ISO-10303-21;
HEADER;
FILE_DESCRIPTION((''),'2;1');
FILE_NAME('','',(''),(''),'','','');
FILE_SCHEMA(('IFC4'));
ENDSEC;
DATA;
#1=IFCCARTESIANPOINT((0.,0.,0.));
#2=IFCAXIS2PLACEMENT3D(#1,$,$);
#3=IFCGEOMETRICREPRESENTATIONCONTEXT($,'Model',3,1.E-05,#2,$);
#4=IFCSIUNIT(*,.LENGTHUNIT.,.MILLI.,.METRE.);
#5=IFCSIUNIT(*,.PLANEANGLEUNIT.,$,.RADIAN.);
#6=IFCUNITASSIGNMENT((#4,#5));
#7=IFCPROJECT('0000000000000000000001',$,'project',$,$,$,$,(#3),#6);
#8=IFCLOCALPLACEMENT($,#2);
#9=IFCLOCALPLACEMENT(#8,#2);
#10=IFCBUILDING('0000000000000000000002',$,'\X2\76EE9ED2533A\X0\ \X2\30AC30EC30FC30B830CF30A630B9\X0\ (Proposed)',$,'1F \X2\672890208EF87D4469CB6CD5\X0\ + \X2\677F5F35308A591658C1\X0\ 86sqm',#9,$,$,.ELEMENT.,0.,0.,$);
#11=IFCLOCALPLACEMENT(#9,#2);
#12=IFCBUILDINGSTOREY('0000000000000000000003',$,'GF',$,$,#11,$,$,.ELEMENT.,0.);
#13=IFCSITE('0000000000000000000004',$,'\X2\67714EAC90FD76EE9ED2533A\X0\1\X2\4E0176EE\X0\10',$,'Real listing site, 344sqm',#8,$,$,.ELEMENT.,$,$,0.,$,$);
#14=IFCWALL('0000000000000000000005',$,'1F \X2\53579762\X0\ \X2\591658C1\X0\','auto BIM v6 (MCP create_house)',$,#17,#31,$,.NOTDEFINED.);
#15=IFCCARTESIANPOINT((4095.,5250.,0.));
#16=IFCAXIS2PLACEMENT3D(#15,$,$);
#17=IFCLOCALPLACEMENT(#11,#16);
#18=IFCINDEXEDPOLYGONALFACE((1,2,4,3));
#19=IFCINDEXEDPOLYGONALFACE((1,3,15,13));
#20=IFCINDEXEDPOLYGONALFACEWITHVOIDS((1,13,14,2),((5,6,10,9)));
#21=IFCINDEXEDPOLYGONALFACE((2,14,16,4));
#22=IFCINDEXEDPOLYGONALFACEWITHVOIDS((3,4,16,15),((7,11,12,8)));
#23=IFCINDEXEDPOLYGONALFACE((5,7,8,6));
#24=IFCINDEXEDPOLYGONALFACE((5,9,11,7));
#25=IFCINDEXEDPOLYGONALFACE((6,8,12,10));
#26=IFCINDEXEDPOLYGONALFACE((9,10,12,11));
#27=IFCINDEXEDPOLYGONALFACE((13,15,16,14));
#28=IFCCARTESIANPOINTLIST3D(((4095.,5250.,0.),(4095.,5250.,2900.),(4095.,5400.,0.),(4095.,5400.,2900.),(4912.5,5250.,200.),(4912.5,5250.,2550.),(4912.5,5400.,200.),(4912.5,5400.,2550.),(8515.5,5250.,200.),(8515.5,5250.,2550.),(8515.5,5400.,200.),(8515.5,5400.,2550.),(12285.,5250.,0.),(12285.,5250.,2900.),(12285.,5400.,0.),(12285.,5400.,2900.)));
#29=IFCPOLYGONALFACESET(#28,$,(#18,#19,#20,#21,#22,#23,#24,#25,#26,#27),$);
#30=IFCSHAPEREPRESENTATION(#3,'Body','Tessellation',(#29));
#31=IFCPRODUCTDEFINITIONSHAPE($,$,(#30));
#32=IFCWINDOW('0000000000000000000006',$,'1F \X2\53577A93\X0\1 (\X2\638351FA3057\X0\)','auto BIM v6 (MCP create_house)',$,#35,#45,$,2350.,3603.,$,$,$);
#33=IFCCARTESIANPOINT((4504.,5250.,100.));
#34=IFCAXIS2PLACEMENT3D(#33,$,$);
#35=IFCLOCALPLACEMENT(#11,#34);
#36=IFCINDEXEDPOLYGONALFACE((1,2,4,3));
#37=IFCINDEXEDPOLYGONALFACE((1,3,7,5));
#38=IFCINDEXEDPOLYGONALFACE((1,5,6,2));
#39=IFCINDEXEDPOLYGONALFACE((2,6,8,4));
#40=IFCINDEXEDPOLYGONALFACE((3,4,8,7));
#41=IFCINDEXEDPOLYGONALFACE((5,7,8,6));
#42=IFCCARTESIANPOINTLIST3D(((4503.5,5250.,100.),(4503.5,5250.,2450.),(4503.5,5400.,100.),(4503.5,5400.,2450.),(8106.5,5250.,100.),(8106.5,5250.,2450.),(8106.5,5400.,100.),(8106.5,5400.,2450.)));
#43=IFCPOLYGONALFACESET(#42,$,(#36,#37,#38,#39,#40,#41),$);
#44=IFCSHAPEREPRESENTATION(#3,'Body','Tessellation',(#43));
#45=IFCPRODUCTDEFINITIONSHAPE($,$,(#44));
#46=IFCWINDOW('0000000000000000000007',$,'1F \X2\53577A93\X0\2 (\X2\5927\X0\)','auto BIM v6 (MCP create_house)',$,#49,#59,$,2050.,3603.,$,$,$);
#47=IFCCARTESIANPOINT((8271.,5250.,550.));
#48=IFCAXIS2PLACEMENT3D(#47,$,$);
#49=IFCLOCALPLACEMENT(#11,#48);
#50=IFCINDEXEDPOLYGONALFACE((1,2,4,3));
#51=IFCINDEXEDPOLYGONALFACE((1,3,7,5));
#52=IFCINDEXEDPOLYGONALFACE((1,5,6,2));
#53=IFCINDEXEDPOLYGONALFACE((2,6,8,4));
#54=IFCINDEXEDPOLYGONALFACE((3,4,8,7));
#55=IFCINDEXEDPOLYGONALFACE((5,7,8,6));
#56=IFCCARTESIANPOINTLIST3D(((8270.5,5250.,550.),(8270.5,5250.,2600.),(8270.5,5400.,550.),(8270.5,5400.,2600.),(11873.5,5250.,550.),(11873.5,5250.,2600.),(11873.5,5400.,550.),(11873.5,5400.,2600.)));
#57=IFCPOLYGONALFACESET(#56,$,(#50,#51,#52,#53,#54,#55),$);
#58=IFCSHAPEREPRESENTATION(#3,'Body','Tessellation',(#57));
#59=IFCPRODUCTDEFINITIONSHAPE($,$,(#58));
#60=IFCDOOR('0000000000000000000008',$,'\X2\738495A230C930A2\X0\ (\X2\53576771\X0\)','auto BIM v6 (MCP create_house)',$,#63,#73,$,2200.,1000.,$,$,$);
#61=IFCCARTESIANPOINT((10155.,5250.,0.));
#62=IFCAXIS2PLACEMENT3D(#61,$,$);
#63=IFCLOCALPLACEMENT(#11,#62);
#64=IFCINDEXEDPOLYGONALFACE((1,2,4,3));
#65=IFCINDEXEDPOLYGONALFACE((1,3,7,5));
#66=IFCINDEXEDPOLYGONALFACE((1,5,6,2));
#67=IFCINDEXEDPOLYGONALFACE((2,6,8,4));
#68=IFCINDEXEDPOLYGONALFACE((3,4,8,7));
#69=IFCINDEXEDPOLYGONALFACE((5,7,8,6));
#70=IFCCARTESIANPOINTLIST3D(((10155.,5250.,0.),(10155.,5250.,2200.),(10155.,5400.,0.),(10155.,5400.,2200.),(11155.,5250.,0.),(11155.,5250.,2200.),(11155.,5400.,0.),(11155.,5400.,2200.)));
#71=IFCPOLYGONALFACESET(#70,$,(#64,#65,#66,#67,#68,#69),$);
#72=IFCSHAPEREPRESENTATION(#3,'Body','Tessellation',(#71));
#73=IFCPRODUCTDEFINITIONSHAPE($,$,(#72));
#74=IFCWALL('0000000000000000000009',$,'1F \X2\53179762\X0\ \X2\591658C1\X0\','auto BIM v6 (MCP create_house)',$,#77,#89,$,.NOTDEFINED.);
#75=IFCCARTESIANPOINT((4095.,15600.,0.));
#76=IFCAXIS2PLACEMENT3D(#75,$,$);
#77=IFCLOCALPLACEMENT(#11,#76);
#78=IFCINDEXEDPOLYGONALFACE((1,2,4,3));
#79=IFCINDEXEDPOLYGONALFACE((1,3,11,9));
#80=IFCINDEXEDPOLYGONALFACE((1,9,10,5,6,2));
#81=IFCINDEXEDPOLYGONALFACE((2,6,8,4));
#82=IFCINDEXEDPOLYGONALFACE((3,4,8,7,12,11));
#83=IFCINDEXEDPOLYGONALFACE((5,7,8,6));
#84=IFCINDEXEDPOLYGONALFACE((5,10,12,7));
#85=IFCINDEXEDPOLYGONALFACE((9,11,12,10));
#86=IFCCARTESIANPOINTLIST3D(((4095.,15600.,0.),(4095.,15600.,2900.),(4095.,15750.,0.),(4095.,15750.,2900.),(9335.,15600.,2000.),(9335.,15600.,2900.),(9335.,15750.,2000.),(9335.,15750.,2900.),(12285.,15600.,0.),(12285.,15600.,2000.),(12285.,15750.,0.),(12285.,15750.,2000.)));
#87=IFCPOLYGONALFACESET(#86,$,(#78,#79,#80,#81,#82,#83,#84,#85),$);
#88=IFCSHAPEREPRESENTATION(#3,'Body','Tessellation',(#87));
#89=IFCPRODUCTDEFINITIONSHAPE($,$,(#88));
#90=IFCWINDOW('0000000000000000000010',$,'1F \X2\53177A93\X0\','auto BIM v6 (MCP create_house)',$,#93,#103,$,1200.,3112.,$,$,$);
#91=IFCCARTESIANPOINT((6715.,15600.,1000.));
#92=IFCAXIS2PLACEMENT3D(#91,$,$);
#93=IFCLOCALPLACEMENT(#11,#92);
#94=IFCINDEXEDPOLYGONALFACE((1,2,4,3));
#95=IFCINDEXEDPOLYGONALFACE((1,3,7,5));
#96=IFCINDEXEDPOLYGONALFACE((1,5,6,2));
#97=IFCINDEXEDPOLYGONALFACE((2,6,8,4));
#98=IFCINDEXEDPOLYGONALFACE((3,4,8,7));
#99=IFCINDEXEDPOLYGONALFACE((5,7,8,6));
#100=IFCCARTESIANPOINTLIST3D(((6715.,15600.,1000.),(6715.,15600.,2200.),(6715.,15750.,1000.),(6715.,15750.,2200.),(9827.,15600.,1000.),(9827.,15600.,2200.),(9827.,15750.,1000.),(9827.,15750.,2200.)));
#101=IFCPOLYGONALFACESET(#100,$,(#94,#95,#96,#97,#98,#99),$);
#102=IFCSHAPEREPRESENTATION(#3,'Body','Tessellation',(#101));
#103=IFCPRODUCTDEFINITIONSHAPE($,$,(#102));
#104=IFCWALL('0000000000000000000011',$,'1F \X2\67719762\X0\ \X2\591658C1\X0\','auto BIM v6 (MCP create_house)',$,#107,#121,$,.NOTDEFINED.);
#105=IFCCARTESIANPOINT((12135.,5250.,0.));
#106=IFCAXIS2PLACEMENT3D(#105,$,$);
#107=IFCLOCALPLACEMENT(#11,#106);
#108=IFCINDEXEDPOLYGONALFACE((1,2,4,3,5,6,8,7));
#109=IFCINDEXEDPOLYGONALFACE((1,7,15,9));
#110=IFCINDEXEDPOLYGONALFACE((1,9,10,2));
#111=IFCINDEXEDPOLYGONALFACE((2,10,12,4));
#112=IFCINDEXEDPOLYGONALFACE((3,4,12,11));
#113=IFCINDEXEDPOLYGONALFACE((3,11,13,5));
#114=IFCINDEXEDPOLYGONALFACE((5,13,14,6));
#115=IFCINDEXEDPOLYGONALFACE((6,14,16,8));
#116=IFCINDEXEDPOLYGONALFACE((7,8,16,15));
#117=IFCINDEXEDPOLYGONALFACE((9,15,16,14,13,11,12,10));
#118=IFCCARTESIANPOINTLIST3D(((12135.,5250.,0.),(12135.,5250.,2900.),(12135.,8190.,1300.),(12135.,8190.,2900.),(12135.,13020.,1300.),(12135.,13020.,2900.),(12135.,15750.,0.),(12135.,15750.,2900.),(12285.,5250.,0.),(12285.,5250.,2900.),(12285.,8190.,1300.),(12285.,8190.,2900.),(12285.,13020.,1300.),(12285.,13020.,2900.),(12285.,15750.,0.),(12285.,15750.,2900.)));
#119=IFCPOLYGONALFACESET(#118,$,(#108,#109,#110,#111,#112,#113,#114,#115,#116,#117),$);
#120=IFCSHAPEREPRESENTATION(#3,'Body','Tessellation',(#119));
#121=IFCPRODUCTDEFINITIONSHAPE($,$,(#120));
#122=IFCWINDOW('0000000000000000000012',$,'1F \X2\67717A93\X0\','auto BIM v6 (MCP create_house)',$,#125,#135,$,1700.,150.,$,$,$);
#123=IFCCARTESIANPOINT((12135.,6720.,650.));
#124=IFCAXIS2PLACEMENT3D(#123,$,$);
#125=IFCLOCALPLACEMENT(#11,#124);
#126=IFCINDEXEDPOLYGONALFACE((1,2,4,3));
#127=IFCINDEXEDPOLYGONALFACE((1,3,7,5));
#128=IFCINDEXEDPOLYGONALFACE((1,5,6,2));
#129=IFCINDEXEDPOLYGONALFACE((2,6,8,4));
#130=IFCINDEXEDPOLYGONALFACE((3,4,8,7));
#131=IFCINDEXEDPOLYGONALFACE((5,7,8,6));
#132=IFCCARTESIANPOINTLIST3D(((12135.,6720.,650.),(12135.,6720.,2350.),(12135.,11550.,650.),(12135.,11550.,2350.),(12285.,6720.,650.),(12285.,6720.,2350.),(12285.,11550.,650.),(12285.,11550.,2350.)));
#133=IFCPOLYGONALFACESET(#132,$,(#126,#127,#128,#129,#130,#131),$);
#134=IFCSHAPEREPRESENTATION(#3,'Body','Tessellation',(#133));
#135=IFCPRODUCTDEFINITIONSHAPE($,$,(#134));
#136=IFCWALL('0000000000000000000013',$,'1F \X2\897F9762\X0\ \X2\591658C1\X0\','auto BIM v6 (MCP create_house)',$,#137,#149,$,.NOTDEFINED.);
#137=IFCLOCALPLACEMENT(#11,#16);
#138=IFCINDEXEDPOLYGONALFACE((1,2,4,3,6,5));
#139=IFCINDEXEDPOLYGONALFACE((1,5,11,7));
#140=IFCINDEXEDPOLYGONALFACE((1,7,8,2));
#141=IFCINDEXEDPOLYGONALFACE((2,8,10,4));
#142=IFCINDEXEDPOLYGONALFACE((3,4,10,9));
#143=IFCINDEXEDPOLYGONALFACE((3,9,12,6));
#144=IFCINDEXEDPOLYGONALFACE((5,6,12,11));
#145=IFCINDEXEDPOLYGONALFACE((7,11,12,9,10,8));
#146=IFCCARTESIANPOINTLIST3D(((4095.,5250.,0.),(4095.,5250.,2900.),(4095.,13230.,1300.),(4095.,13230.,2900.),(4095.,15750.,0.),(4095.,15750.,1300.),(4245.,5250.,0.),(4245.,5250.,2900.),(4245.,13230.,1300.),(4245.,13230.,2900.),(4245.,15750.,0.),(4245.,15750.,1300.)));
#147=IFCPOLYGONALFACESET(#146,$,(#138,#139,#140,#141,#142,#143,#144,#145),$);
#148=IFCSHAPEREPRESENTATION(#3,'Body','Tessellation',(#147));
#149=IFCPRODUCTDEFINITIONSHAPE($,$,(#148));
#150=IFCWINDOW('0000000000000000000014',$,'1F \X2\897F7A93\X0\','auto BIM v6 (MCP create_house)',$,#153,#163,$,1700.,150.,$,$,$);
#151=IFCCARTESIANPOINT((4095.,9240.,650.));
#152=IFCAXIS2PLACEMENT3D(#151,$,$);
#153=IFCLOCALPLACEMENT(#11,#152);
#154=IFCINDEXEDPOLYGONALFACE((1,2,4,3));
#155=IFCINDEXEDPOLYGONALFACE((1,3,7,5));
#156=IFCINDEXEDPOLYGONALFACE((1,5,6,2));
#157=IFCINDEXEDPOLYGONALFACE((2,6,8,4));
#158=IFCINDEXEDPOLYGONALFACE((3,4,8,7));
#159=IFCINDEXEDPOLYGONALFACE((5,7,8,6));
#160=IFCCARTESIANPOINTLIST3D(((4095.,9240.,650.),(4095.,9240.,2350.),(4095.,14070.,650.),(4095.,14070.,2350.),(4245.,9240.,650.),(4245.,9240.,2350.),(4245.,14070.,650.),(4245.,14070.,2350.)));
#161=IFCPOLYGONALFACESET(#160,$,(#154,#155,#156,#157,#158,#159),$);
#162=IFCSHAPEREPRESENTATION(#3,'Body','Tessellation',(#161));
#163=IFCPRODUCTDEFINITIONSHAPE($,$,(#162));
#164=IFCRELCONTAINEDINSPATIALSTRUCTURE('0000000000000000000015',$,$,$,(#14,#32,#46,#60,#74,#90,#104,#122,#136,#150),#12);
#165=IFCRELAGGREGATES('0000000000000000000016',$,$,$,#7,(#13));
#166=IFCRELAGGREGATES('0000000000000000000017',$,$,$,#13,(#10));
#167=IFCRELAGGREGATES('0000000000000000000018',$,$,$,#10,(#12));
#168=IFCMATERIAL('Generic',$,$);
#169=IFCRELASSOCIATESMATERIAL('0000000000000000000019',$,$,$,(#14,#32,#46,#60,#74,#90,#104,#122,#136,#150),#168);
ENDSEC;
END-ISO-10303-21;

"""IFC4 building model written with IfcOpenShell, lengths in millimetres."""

from ifc_helpers import new_model, si_unit, frame, frame_2d, origin, place, context, project, spatial, rectangle, extrude, material, element, fill, save


model = new_model("IFC4")

# Units and contexts
model_context = context("Model", 3, precision=1e-05, world=origin())
ifc_project = project(units=[si_unit("LENGTHUNIT", "METRE", prefix="MILLI"), si_unit("PLANEANGLEUNIT", "RADIAN")], contexts=[model_context])

# Site, building, storey
site_placement = place(None, origin())
site = spatial("IfcSite", under=ifc_project, at=site_placement, Name="東京都目黒区1丁目10", ObjectType="Real listing site, 344sqm", CompositionType="ELEMENT", RefElevation=0.0)
building_placement = place(site_placement, origin())
building = spatial("IfcBuilding", under=site, at=building_placement, Name="目黒区 ガレージハウス (Proposed)", ObjectType="1F 木造軸組構法 + 板張り外壁 86sqm", CompositionType="ELEMENT", ElevationOfRefHeight=0.0, ElevationOfTerrain=0.0)
storey_placement = place(building_placement, origin())
storey = spatial("IfcBuildingStorey", under=building, at=storey_placement, Name="GF", CompositionType="ELEMENT", Elevation=0.0)

# Shared definitions
ifc_material = material(Name="Generic")

# Wall, openings, windows, door
wall_1_placement = place(storey_placement, frame((4095.0, 5250.0, 0.0)))
wall_1 = element("IfcWall", 1, at=wall_1_placement, inside=storey, material=ifc_material, Name="1F 南面 外壁", Description="auto BIM v6 (MCP create_house)", PredefinedType="NOTDEFINED", context=model_context, shape_type="SweptSolid", body=[
    extrude(rectangle(XDim=8190.0, YDim=150.0, at=frame_2d((4095.0, 75.0))), frame((4095.0, 5250.0, 0.0)), (0.0, 0.0, 1.0), 2900.0),
])
opening_1_placement = place(storey_placement, frame((4504.0, 5250.0, 100.0)))
opening_1 = element("IfcOpeningElement", 2, at=opening_1_placement, cuts=wall_1, PredefinedType="NOTDEFINED", context=model_context, shape_type="SweptSolid", body=[
    extrude(rectangle(XDim=3603.0, YDim=150.0, at=frame_2d((1801.0, 75.0))), frame((4504.0, 5250.0, 100.0)), (0.0, 0.0, 1.0), 2350.0),
])
opening_2_placement = place(storey_placement, frame((8271.0, 5250.0, 550.0)))
opening_2 = element("IfcOpeningElement", 3, at=opening_2_placement, cuts=wall_1, PredefinedType="NOTDEFINED", context=model_context, shape_type="SweptSolid", body=[
    extrude(rectangle(XDim=3603.0, YDim=150.0, at=frame_2d((1801.0, 75.0))), frame((8271.0, 5250.0, 550.0)), (0.0, 0.0, 1.0), 2050.0),
])
opening_3_placement = place(storey_placement, frame((10155.0, 5250.0, 0.0)))
opening_3 = element("IfcOpeningElement", 4, at=opening_3_placement, cuts=wall_1, PredefinedType="NOTDEFINED", context=model_context, shape_type="SweptSolid", body=[
    extrude(rectangle(XDim=1000.0, YDim=150.0, at=frame_2d((500.0, 75.0))), frame((10155.0, 5250.0, 0.0)), (0.0, 0.0, 1.0), 2200.0),
])
window_1_placement = place(storey_placement, frame((4504.0, 5250.0, 100.0)))
window_1 = element("IfcWindow", 5, at=window_1_placement, inside=storey, material=ifc_material, Name="1F 南窓1 (掃出し)", Description="auto BIM v6 (MCP create_house)", OverallHeight=2350.0, OverallWidth=3603.0, context=model_context, shape_type="SweptSolid", body=[
    extrude(rectangle(XDim=3603.0, YDim=150.0, at=frame_2d((1801.0, 75.0))), frame((4504.0, 5250.0, 100.0)), (0.0, 0.0, 1.0), 2350.0),
])
fill(opening_1, window_1)
window_2_placement = place(storey_placement, frame((8271.0, 5250.0, 550.0)))
window_2 = element("IfcWindow", 6, at=window_2_placement, inside=storey, material=ifc_material, Name="1F 南窓2 (大)", Description="auto BIM v6 (MCP create_house)", OverallHeight=2050.0, OverallWidth=3603.0, context=model_context, shape_type="SweptSolid", body=[
    extrude(rectangle(XDim=3603.0, YDim=150.0, at=frame_2d((1801.0, 75.0))), frame((8271.0, 5250.0, 550.0)), (0.0, 0.0, 1.0), 2050.0),
])
fill(opening_2, window_2)
door_placement = place(storey_placement, frame((10155.0, 5250.0, 0.0)))
door = element("IfcDoor", 7, at=door_placement, inside=storey, material=ifc_material, Name="玄関ドア (南東)", Description="auto BIM v6 (MCP create_house)", OverallHeight=2200.0, OverallWidth=1000.0, context=model_context, shape_type="SweptSolid", body=[
    extrude(rectangle(XDim=1000.0, YDim=150.0, at=frame_2d((500.0, 75.0))), frame((10155.0, 5250.0, 0.0)), (0.0, 0.0, 1.0), 2200.0),
])
fill(opening_3, door)

# Walls, openings, windows
wall_2_placement = place(storey_placement, frame((4095.0, 15600.0, 0.0)))
wall_2 = element("IfcWall", 8, at=wall_2_placement, inside=storey, material=ifc_material, Name="1F 北面 外壁", Description="auto BIM v6 (MCP create_house)", PredefinedType="NOTDEFINED", context=model_context, shape_type="SweptSolid", body=[
    extrude(rectangle(XDim=8190.0, YDim=150.0, at=frame_2d((4095.0, 75.0))), frame((4095.0, 15600.0, 0.0)), (0.0, 0.0, 1.0), 2900.0),
])
opening_4_placement = place(storey_placement, frame((6715.0, 15600.0, 1000.0)))
opening_4 = element("IfcOpeningElement", 9, at=opening_4_placement, cuts=wall_2, PredefinedType="NOTDEFINED", context=model_context, shape_type="SweptSolid", body=[
    extrude(rectangle(XDim=3112.0, YDim=150.0, at=frame_2d((1556.0, 75.0))), frame((6715.0, 15600.0, 1000.0)), (0.0, 0.0, 1.0), 1200.0),
])
window_3_placement = place(storey_placement, frame((6715.0, 15600.0, 1000.0)))
window_3 = element("IfcWindow", 10, at=window_3_placement, inside=storey, material=ifc_material, Name="1F 北窓", Description="auto BIM v6 (MCP create_house)", OverallHeight=1200.0, OverallWidth=3112.0, context=model_context, shape_type="SweptSolid", body=[
    extrude(rectangle(XDim=3112.0, YDim=150.0, at=frame_2d((1556.0, 75.0))), frame((6715.0, 15600.0, 1000.0)), (0.0, 0.0, 1.0), 1200.0),
])
fill(opening_4, window_3)
wall_3_placement = place(storey_placement, frame((12135.0, 5250.0, 0.0)))
wall_3 = element("IfcWall", 11, at=wall_3_placement, inside=storey, material=ifc_material, Name="1F 東面 外壁", Description="auto BIM v6 (MCP create_house)", PredefinedType="NOTDEFINED", context=model_context, shape_type="SweptSolid", body=[
    extrude(rectangle(XDim=150.0, YDim=10500.0, at=frame_2d((75.0, 5250.0))), frame((12135.0, 5250.0, 0.0)), (0.0, 0.0, 1.0), 2900.0),
])
opening_5_placement = place(storey_placement, frame((12135.0, 6720.0, 650.0)))
opening_5 = element("IfcOpeningElement", 12, at=opening_5_placement, cuts=wall_3, PredefinedType="NOTDEFINED", context=model_context, shape_type="SweptSolid", body=[
    extrude(rectangle(XDim=150.0, YDim=4830.0, at=frame_2d((75.0, 2415.0))), frame((12135.0, 6720.0, 650.0)), (0.0, 0.0, 1.0), 1700.0),
])
window_4_placement = place(storey_placement, frame((12135.0, 6720.0, 650.0)))
window_4 = element("IfcWindow", 13, at=window_4_placement, inside=storey, material=ifc_material, Name="1F 東窓", Description="auto BIM v6 (MCP create_house)", OverallHeight=1700.0, OverallWidth=150.0, context=model_context, shape_type="SweptSolid", body=[
    extrude(rectangle(XDim=150.0, YDim=4830.0, at=frame_2d((75.0, 2415.0))), frame((12135.0, 6720.0, 650.0)), (0.0, 0.0, 1.0), 1700.0),
])
fill(opening_5, window_4)
wall_4_placement = place(storey_placement, frame((4095.0, 5250.0, 0.0)))
wall_4 = element("IfcWall", 14, at=wall_4_placement, inside=storey, material=ifc_material, Name="1F 西面 外壁", Description="auto BIM v6 (MCP create_house)", PredefinedType="NOTDEFINED", context=model_context, shape_type="SweptSolid", body=[
    extrude(rectangle(XDim=150.0, YDim=10500.0, at=frame_2d((75.0, 5250.0))), frame((4095.0, 5250.0, 0.0)), (0.0, 0.0, 1.0), 2900.0),
])
opening_6_placement = place(storey_placement, frame((4095.0, 9240.0, 650.0)))
opening_6 = element("IfcOpeningElement", 15, at=opening_6_placement, cuts=wall_4, PredefinedType="NOTDEFINED", context=model_context, shape_type="SweptSolid", body=[
    extrude(rectangle(XDim=150.0, YDim=4830.0, at=frame_2d((75.0, 2415.0))), frame((4095.0, 9240.0, 650.0)), (0.0, 0.0, 1.0), 1700.0),
])
window_5_placement = place(storey_placement, frame((4095.0, 9240.0, 650.0)))
window_5 = element("IfcWindow", 16, at=window_5_placement, inside=storey, material=ifc_material, Name="1F 西窓", Description="auto BIM v6 (MCP create_house)", OverallHeight=1700.0, OverallWidth=150.0, context=model_context, shape_type="SweptSolid", body=[
    extrude(rectangle(XDim=150.0, YDim=4830.0, at=frame_2d((75.0, 2415.0))), frame((4095.0, 9240.0, 650.0)), (0.0, 0.0, 1.0), 1700.0),
])
fill(opening_6, window_5)

save(model, "model.ifc")
